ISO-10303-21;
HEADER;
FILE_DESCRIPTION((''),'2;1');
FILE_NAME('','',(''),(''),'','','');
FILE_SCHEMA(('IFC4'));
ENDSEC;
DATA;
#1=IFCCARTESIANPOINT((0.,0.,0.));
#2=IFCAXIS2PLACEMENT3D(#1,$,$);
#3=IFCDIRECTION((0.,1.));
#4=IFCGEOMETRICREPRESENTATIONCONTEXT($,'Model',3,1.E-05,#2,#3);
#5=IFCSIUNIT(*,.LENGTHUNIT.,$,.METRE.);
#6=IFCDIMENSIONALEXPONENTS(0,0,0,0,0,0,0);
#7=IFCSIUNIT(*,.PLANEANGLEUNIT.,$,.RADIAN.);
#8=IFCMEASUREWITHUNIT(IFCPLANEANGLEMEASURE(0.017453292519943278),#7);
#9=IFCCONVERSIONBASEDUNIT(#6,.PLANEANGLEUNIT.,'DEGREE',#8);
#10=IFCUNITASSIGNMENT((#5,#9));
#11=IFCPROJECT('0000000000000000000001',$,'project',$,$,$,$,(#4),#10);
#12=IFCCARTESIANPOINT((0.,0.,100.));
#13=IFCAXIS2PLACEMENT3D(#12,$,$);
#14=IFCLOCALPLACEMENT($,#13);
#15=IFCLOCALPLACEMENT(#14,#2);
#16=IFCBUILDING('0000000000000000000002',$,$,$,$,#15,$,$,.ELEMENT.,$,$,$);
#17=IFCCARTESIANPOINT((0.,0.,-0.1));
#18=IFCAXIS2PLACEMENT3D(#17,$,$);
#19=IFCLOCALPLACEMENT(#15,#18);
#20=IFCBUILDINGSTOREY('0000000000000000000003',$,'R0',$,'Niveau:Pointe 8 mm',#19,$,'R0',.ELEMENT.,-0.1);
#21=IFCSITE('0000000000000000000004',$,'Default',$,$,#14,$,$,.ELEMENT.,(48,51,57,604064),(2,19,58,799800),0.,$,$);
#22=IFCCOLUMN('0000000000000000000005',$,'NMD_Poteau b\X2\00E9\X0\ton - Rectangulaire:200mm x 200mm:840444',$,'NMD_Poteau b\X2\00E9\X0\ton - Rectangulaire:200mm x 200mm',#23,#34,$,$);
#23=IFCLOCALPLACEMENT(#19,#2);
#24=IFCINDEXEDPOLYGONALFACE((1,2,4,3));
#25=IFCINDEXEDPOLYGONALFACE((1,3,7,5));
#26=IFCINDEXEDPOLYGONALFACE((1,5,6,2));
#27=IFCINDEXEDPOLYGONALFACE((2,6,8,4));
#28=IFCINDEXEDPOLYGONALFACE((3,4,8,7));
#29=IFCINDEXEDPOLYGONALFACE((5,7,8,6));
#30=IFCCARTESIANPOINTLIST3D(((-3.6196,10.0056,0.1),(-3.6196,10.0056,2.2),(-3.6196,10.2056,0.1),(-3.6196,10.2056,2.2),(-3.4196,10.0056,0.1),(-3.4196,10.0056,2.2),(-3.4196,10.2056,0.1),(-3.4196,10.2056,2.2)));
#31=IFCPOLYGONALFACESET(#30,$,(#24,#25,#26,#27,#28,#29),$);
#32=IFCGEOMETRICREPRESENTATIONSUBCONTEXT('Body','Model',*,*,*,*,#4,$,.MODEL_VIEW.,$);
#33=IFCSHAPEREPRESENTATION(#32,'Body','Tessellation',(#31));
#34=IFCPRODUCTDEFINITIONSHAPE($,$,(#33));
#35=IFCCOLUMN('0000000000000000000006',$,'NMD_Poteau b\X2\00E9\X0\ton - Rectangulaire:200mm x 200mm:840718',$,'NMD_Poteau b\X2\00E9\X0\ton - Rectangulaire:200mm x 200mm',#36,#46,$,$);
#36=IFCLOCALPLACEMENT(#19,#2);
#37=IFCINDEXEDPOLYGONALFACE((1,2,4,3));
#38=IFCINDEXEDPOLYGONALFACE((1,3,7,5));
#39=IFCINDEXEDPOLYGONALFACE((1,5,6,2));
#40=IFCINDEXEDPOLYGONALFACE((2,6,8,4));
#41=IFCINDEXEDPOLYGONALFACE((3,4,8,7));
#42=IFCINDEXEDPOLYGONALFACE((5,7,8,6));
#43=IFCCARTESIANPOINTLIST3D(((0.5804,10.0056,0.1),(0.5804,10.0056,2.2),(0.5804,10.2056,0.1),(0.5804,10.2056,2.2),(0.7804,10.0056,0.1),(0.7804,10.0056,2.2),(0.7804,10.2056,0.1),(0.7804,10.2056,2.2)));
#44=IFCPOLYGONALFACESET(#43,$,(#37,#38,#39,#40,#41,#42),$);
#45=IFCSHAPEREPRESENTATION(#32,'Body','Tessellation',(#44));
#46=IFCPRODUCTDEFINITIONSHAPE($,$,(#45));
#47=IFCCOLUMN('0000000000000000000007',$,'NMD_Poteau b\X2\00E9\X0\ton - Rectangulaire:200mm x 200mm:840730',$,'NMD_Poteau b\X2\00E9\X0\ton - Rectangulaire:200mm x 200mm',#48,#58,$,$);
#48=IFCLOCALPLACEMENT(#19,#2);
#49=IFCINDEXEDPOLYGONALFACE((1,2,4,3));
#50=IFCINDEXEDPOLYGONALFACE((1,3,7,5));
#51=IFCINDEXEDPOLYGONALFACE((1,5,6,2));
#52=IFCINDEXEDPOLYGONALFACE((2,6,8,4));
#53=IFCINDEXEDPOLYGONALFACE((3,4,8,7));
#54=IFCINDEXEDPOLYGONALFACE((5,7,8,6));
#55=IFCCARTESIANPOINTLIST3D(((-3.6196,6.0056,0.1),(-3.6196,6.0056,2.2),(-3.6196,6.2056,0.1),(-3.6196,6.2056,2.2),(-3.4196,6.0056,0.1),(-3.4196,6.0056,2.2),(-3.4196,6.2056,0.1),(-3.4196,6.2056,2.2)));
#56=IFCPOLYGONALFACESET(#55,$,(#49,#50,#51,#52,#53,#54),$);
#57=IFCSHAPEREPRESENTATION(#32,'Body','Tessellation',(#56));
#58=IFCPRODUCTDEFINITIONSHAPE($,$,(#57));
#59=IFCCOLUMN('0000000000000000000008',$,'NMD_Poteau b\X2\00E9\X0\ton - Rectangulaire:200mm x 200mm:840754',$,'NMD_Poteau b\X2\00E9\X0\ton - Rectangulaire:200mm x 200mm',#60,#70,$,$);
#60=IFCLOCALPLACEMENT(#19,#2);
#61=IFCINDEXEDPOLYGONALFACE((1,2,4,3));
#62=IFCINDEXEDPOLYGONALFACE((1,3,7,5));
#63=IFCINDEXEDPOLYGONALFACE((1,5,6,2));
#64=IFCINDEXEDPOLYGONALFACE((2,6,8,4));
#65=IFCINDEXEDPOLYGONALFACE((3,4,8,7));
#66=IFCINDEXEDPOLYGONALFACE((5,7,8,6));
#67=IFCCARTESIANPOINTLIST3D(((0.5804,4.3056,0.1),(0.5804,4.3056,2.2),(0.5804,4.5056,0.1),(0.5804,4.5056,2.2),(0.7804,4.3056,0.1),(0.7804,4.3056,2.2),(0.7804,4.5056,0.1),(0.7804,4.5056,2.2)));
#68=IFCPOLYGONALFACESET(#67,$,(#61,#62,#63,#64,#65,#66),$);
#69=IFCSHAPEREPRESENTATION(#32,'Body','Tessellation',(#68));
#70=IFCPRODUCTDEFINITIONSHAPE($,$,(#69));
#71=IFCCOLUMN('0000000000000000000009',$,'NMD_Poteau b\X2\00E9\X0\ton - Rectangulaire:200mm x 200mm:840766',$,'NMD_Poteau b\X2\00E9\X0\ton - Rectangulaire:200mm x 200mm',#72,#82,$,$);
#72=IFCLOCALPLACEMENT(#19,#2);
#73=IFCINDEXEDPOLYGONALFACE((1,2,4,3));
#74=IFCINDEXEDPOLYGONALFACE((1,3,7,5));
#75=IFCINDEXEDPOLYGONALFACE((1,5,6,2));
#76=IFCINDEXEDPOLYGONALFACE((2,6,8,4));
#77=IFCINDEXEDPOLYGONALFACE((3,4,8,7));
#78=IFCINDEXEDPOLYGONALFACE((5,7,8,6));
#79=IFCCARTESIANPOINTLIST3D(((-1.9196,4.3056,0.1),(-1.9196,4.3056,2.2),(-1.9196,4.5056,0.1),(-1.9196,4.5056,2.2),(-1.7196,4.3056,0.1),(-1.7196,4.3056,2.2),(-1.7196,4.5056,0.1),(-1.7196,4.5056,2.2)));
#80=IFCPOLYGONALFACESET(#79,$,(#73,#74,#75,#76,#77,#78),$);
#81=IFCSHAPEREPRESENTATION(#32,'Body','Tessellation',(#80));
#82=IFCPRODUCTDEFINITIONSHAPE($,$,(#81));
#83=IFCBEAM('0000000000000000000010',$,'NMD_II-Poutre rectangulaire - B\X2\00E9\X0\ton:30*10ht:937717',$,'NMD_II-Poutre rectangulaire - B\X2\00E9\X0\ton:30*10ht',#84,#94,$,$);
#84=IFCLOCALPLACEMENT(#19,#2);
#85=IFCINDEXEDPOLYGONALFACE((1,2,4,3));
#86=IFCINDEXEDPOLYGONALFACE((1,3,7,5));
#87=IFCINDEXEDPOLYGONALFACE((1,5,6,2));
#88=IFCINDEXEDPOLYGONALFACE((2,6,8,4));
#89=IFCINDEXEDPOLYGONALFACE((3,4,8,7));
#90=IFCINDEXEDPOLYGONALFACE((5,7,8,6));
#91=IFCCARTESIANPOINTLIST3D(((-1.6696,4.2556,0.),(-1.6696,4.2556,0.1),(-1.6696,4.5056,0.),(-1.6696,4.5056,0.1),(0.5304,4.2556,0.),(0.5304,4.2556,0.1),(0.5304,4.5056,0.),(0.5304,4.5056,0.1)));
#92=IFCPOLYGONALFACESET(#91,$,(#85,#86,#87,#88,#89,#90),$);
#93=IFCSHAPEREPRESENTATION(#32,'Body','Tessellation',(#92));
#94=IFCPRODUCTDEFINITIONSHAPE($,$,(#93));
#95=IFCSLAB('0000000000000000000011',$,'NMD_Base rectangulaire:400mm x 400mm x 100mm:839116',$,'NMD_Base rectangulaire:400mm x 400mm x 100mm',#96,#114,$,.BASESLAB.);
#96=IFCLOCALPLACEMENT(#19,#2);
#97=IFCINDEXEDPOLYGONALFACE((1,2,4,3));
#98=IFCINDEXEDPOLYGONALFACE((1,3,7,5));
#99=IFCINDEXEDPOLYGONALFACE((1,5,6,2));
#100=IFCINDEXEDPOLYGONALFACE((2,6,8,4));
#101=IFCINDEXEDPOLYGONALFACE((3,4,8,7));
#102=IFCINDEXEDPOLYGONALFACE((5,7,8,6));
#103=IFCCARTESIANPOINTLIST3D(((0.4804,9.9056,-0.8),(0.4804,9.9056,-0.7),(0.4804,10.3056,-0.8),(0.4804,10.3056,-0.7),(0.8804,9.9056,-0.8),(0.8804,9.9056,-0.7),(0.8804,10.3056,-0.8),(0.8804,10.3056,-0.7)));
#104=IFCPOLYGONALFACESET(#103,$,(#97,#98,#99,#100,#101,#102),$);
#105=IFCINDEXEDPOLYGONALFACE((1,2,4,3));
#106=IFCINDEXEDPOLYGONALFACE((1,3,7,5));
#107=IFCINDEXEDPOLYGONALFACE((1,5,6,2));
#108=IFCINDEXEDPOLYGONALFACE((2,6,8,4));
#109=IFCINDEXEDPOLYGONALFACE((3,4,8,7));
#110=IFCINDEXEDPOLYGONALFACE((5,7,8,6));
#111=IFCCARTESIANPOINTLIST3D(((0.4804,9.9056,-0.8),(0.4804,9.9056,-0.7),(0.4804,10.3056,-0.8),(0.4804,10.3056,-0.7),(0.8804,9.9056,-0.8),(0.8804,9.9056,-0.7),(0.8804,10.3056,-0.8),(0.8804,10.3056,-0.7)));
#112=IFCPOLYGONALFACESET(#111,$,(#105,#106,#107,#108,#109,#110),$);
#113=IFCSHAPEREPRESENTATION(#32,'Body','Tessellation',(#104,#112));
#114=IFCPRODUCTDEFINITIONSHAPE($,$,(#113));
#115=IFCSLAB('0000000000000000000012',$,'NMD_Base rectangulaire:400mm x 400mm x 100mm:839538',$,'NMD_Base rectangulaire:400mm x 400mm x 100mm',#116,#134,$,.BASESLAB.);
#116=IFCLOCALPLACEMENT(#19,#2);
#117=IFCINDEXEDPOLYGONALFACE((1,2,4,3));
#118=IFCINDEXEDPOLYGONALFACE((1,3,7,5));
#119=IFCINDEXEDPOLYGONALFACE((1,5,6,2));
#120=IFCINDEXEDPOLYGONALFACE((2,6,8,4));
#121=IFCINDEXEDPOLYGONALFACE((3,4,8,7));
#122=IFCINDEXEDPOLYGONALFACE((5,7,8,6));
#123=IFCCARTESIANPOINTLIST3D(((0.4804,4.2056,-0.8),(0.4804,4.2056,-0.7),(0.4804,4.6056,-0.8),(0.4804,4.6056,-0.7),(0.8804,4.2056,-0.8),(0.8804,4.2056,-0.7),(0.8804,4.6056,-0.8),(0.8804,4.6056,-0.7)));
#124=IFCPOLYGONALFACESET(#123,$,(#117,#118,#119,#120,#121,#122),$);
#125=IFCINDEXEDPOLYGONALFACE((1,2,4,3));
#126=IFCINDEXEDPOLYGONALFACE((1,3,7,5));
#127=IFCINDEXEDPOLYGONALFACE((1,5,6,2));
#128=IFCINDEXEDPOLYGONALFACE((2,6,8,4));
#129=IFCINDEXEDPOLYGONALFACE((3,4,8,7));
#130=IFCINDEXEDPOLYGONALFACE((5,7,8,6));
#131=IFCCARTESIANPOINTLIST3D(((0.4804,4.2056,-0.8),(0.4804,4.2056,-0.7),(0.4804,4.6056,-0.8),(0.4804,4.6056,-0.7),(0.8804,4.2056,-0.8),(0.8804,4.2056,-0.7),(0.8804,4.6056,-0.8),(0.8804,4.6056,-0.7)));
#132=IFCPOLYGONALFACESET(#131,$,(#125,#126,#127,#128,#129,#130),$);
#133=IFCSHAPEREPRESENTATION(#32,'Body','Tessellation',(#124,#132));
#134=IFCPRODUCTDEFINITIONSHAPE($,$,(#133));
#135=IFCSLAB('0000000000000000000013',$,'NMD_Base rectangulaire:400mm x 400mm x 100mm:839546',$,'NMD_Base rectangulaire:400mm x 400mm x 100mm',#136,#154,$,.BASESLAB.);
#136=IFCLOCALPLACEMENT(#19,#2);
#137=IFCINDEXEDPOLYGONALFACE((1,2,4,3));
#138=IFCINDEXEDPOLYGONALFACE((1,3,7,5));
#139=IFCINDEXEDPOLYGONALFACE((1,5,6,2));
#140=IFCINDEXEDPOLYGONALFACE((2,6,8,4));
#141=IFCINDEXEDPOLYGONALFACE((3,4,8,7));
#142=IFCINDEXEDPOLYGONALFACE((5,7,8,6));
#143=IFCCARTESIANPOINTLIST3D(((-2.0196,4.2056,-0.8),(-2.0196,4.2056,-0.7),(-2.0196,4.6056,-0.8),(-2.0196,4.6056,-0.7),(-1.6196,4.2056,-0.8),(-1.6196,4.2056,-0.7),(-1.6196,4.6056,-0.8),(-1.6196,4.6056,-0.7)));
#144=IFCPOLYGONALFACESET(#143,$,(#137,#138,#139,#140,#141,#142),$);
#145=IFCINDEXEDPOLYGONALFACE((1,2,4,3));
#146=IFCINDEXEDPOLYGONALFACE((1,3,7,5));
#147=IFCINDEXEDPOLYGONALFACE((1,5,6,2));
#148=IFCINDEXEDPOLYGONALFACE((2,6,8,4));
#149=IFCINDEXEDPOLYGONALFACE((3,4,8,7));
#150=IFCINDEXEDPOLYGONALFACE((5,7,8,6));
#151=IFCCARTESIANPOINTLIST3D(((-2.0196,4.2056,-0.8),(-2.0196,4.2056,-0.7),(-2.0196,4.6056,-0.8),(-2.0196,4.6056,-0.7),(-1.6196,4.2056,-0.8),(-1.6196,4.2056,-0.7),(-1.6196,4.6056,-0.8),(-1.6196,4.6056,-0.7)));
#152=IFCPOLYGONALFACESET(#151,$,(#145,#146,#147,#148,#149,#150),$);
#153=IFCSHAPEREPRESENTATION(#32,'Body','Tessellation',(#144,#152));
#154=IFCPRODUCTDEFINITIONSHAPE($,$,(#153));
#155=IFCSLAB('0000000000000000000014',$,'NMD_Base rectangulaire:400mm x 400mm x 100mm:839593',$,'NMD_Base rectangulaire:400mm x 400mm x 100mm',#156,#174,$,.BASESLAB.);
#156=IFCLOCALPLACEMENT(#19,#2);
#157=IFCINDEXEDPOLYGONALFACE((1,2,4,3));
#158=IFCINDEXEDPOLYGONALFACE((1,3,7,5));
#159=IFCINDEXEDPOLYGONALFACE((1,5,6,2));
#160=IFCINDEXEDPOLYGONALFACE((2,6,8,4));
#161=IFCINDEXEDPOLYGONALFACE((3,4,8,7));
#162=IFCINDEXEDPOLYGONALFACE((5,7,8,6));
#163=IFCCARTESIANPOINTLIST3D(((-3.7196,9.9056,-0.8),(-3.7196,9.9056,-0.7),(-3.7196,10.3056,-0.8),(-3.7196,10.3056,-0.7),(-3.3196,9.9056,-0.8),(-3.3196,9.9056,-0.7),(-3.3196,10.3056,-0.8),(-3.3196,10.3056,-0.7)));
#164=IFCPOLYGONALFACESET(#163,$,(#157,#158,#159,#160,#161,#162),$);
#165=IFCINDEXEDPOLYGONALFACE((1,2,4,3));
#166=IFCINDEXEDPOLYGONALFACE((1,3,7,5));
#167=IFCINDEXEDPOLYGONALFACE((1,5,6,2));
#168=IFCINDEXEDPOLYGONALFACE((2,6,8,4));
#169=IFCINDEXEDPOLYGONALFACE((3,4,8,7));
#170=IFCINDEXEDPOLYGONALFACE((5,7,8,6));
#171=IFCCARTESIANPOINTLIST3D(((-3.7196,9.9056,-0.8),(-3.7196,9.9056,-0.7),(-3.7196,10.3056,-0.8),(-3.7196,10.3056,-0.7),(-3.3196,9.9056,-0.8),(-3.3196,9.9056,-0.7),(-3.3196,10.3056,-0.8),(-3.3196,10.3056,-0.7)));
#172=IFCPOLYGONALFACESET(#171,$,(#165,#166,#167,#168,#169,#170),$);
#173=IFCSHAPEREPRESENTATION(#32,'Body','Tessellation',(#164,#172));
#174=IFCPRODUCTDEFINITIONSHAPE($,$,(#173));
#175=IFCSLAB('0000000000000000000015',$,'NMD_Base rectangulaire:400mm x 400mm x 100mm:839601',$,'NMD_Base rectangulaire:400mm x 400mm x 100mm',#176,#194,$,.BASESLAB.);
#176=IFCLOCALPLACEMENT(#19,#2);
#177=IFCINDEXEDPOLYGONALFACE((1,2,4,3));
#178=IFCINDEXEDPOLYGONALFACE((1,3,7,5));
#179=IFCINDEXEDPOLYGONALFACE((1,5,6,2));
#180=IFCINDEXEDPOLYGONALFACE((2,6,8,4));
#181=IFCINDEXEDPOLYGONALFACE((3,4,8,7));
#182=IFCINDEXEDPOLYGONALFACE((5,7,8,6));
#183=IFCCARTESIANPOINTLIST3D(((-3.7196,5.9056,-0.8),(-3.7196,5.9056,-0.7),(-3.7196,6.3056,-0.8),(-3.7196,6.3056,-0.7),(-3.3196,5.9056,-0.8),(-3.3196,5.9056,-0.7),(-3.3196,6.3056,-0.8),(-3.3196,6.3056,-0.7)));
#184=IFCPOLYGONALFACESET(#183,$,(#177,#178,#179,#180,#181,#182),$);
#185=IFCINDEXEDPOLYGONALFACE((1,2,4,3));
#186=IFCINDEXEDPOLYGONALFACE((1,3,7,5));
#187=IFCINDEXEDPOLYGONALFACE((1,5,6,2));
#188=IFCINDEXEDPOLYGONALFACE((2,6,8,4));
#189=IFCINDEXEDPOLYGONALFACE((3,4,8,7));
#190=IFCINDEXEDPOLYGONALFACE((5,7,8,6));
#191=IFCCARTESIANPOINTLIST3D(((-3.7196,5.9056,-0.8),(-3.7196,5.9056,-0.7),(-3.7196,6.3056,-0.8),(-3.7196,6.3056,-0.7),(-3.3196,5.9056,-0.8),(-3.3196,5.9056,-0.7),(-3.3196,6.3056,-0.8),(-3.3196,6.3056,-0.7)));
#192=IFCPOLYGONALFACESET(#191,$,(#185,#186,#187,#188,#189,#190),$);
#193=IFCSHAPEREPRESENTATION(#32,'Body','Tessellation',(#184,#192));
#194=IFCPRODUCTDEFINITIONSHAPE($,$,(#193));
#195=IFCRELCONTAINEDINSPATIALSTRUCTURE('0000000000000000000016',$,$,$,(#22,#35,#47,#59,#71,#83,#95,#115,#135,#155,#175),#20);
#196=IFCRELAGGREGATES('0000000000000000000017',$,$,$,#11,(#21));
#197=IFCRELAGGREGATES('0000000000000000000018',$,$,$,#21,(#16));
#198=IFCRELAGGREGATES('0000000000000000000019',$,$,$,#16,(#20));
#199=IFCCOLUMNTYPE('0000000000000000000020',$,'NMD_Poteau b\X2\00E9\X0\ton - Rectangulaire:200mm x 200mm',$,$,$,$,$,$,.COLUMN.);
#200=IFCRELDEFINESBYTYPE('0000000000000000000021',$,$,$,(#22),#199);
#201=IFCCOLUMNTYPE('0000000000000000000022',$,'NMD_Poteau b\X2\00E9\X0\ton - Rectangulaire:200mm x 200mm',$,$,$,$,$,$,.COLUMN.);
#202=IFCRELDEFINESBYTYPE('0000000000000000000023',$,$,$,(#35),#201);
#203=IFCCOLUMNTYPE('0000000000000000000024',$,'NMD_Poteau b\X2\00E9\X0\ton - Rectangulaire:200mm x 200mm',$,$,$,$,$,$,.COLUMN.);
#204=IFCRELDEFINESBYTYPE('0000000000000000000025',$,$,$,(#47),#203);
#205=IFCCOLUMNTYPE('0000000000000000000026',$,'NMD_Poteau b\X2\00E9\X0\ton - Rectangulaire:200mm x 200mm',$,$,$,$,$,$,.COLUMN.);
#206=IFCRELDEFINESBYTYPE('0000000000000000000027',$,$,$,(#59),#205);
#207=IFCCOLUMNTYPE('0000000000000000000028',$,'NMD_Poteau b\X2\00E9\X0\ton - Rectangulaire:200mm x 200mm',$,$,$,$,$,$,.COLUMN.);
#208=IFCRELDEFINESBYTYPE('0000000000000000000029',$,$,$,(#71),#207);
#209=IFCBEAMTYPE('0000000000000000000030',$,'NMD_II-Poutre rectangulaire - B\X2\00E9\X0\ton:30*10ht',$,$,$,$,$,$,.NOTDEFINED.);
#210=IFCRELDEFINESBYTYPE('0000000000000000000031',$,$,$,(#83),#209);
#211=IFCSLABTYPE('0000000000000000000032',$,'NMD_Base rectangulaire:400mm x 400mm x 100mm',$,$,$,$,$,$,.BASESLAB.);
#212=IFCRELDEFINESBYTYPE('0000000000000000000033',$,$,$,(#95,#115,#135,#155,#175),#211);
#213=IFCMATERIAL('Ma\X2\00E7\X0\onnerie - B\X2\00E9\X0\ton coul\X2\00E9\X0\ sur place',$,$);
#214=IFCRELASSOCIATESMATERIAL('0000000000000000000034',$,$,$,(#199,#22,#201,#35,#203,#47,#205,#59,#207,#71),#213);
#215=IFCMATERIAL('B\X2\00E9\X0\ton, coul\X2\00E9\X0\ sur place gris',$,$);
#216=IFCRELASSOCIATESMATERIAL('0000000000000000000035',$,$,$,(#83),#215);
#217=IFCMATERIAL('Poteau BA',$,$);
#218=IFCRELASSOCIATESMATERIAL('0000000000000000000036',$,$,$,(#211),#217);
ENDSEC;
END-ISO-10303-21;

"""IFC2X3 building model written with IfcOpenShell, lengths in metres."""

from ifc_helpers import new_model, entity, si_unit, converted_unit, direction, frame, frame_2d, origin, origin_2d_with_axis, place, context, subcontext, project, spatial, rectangle, extrude, source, transform, mapped, material, type_object, type_shapes, element, save


model = new_model("IFC2X3")

# Units and contexts
model_context = context("Model", 3, precision=1e-05, world=origin(), true_north=direction((0.0, 1.0)))
body_context = subcontext(model_context, "Body", "Model", "MODEL_VIEW")
ifc_project = project(units=[si_unit("LENGTHUNIT", "METRE"), converted_unit("PLANEANGLEUNIT", "DEGREE", entity("IfcPlaneAngleMeasure", 0.017453292519943278), si_unit("PLANEANGLEUNIT", "RADIAN"), dimensions=[0, 0, 0, 0, 0, 0, 0])], contexts=[model_context])

# Site, building, storey
site_placement = place(None, frame((0.0, 0.0, 100.0)))
site = spatial("IfcSite", under=ifc_project, at=site_placement, Name="Default", CompositionType="ELEMENT", RefLatitude=(48, 51, 57, 604064), RefLongitude=(2, 19, 58, 799800), RefElevation=0.0)
building_placement = place(site_placement, origin())
building = spatial("IfcBuilding", under=site, at=building_placement, CompositionType="ELEMENT")
storey_placement = place(building_placement, frame((0.0, 0.0, -0.1)))
storey = spatial("IfcBuildingStorey", under=building, at=storey_placement, Name="R0", ObjectType="Niveau:Pointe 8 mm", LongName="R0", CompositionType="ELEMENT", Elevation=-0.1)

# Columns
ifc_material_1 = material(Name="Maçonnerie - Béton coulé sur place")
column_type_1 = type_object("IfcColumnType", Name="NMD_Poteau béton - Rectangulaire:200mm x 200mm", PredefinedType="COLUMN", material=ifc_material_1)
shared_shape_1 = source(origin(), body_context, "Body", "SweptSolid", [
    extrude(rectangle(XDim=0.2, YDim=0.2, at=frame_2d((0.0, 0.0), x_axis=(1.0, 0.0))), frame((-3.5196, 10.1056, 0.0), z_axis=(0.0, 0.0, 1.0), x_axis=(-1.0, 0.0, 0.0)), (0.0, 0.0, 1.0), 2.1),
])
type_shapes(column_type_1, [shared_shape_1])
column_1_placement = place(storey_placement, frame((0.0, 0.0, 0.1)))
element("IfcColumn", 1, at=column_1_placement, inside=storey, type_object=column_type_1, material=ifc_material_1, Name="NMD_Poteau béton - Rectangulaire:200mm x 200mm:840444", ObjectType="NMD_Poteau béton - Rectangulaire:200mm x 200mm", context=body_context, shape_type="MappedRepresentation", body=[
    mapped(shared_shape_1, transform((0.0, 0.0, 0.0), scale=1.0)),
])
column_type_2 = type_object("IfcColumnType", Name="NMD_Poteau béton - Rectangulaire:200mm x 200mm", PredefinedType="COLUMN", material=ifc_material_1)
shared_shape_2 = source(origin(), body_context, "Body", "SweptSolid", [
    extrude(rectangle(XDim=0.2, YDim=0.2, at=frame_2d((0.0, 0.0), x_axis=(1.0, 0.0))), frame((0.6804, 10.1056, 0.0), z_axis=(0.0, 0.0, 1.0), x_axis=(-1.0, 0.0, 0.0)), (0.0, 0.0, 1.0), 2.1),
])
type_shapes(column_type_2, [shared_shape_2])
column_2_placement = place(storey_placement, frame((0.0, 0.0, 0.1)))
element("IfcColumn", 2, at=column_2_placement, inside=storey, type_object=column_type_2, material=ifc_material_1, Name="NMD_Poteau béton - Rectangulaire:200mm x 200mm:840718", ObjectType="NMD_Poteau béton - Rectangulaire:200mm x 200mm", context=body_context, shape_type="MappedRepresentation", body=[
    mapped(shared_shape_2, transform((0.0, 0.0, 0.0), scale=1.0)),
])
column_type_3 = type_object("IfcColumnType", Name="NMD_Poteau béton - Rectangulaire:200mm x 200mm", PredefinedType="COLUMN", material=ifc_material_1)
shared_shape_3 = source(origin(), body_context, "Body", "SweptSolid", [
    extrude(rectangle(XDim=0.2, YDim=0.2, at=origin_2d_with_axis()), frame((-3.5196, 6.1056, 0.0), z_axis=(0.0, 0.0, 1.0), x_axis=(-1.0, 0.0, 0.0)), (0.0, 0.0, 1.0), 2.1),
])
type_shapes(column_type_3, [shared_shape_3])
column_3_placement = place(storey_placement, frame((0.0, 0.0, 0.1)))
element("IfcColumn", 3, at=column_3_placement, inside=storey, type_object=column_type_3, material=ifc_material_1, Name="NMD_Poteau béton - Rectangulaire:200mm x 200mm:840730", ObjectType="NMD_Poteau béton - Rectangulaire:200mm x 200mm", context=body_context, shape_type="MappedRepresentation", body=[
    mapped(shared_shape_3, transform((0.0, 0.0, 0.0), scale=1.0)),
])
column_type_4 = type_object("IfcColumnType", Name="NMD_Poteau béton - Rectangulaire:200mm x 200mm", PredefinedType="COLUMN", material=ifc_material_1)
shared_shape_4 = source(origin(), body_context, "Body", "SweptSolid", [
    extrude(rectangle(XDim=0.2, YDim=0.2, at=origin_2d_with_axis()), frame((0.6804, 4.4056, 0.0), z_axis=(0.0, 0.0, 1.0), x_axis=(-1.0, 0.0, 0.0)), (0.0, 0.0, 1.0), 2.1),
])
type_shapes(column_type_4, [shared_shape_4])
column_4_placement = place(storey_placement, frame((0.0, 0.0, 0.1)))
element("IfcColumn", 4, at=column_4_placement, inside=storey, type_object=column_type_4, material=ifc_material_1, Name="NMD_Poteau béton - Rectangulaire:200mm x 200mm:840754", ObjectType="NMD_Poteau béton - Rectangulaire:200mm x 200mm", context=body_context, shape_type="MappedRepresentation", body=[
    mapped(shared_shape_4, transform((0.0, 0.0, 0.0), scale=1.0)),
])
column_type_5 = type_object("IfcColumnType", Name="NMD_Poteau béton - Rectangulaire:200mm x 200mm", PredefinedType="COLUMN", material=ifc_material_1)
shared_shape_5 = source(origin(), body_context, "Body", "SweptSolid", [
    extrude(rectangle(XDim=0.2, YDim=0.2, at=origin_2d_with_axis()), frame((-1.8196, 4.4056, 0.0), z_axis=(0.0, 0.0, 1.0), x_axis=(-1.0, 0.0, 0.0)), (0.0, 0.0, 1.0), 2.1),
])
type_shapes(column_type_5, [shared_shape_5])
column_5_placement = place(storey_placement, frame((0.0, 0.0, 0.1)))
element("IfcColumn", 5, at=column_5_placement, inside=storey, type_object=column_type_5, material=ifc_material_1, Name="NMD_Poteau béton - Rectangulaire:200mm x 200mm:840766", ObjectType="NMD_Poteau béton - Rectangulaire:200mm x 200mm", context=body_context, shape_type="MappedRepresentation", body=[
    mapped(shared_shape_5, transform((0.0, 0.0, 0.0), scale=1.0)),
])

# Beam
ifc_material_2 = material(Name="Béton, coulé sur place gris")
beam_type = type_object("IfcBeamType", Name="NMD_II-Poutre rectangulaire - Béton:30*10ht", PredefinedType="NOTDEFINED")
beam_placement = place(storey_placement, frame((0.5304, 4.4056, 0.1), z_axis=(0.0, 0.0, 1.0), x_axis=(-1.0, 0.0, 0.0)))
element("IfcBeam", 6, at=beam_placement, inside=storey, type_object=beam_type, material=ifc_material_2, Name="NMD_II-Poutre rectangulaire - Béton:30*10ht:937717", ObjectType="NMD_II-Poutre rectangulaire - Béton:30*10ht", context=body_context, shape_type="SweptSolid", body=[
    extrude(rectangle(XDim=0.1, YDim=0.25, at=frame_2d((0.0, 0.0), x_axis=(1.0, 0.0))), frame((0.0, 0.025, -0.05), z_axis=(1.0, 0.0, 0.0), x_axis=(0.0, 0.0, -1.0)), (0.0, 0.0, 1.0), 2.2),
])

# Slabs
ifc_material_3 = material(Name="Poteau BA")
slab_type_1 = type_object("IfcSlabType", Name="NMD_Base rectangulaire:400mm x 400mm x 100mm", PredefinedType="BASESLAB", material=ifc_material_3)
slab_1_placement = place(storey_placement, origin())
element("IfcSlab", 7, at=slab_1_placement, inside=storey, type_object=slab_type_1, Name="NMD_Base rectangulaire:400mm x 400mm x 100mm:839116", ObjectType="NMD_Base rectangulaire:400mm x 400mm x 100mm", PredefinedType="BASESLAB", context=body_context, shape_type="SweptSolid", body=[
    extrude(rectangle(XDim=0.4, YDim=0.4, at=frame_2d((0.0, 0.0), x_axis=(1.0, 0.0))), frame((0.6804, 10.1056, -0.8), z_axis=(0.0, 0.0, 1.0), x_axis=(-1.0, 0.0, 0.0)), (0.0, 0.0, 1.0), 0.1),
    extrude(rectangle(XDim=0.4, YDim=0.4, at=frame_2d((0.0, 0.0), x_axis=(1.0, 0.0))), frame((0.6804, 10.1056, -0.8), z_axis=(0.0, 0.0, 1.0), x_axis=(-1.0, 0.0, 0.0)), (0.0, 0.0, 1.0), 0.1),
])
slab_2_placement = place(storey_placement, origin())
element("IfcSlab", 8, at=slab_2_placement, inside=storey, type_object=slab_type_1, Name="NMD_Base rectangulaire:400mm x 400mm x 100mm:839538", ObjectType="NMD_Base rectangulaire:400mm x 400mm x 100mm", PredefinedType="BASESLAB", context=body_context, shape_type="SweptSolid", body=[
    extrude(rectangle(XDim=0.4, YDim=0.4, at=frame_2d((0.0, 0.0), x_axis=(1.0, 0.0))), frame((0.6804, 4.4056, -0.8), z_axis=(0.0, 0.0, 1.0), x_axis=(-1.0, 0.0, 0.0)), (0.0, 0.0, 1.0), 0.1),
    extrude(rectangle(XDim=0.4, YDim=0.4, at=frame_2d((0.0, 0.0), x_axis=(1.0, 0.0))), frame((0.6804, 4.4056, -0.8), z_axis=(0.0, 0.0, 1.0), x_axis=(-1.0, 0.0, 0.0)), (0.0, 0.0, 1.0), 0.1),
])
slab_3_placement = place(storey_placement, origin())
element("IfcSlab", 9, at=slab_3_placement, inside=storey, type_object=slab_type_1, Name="NMD_Base rectangulaire:400mm x 400mm x 100mm:839546", ObjectType="NMD_Base rectangulaire:400mm x 400mm x 100mm", PredefinedType="BASESLAB", context=body_context, shape_type="SweptSolid", body=[
    extrude(rectangle(XDim=0.4, YDim=0.4, at=origin_2d_with_axis()), frame((-1.8196, 4.4056, -0.8), z_axis=(0.0, 0.0, 1.0), x_axis=(-1.0, 0.0, 0.0)), (0.0, 0.0, 1.0), 0.1),
    extrude(rectangle(XDim=0.4, YDim=0.4, at=origin_2d_with_axis()), frame((-1.8196, 4.4056, -0.8), z_axis=(0.0, 0.0, 1.0), x_axis=(-1.0, 0.0, 0.0)), (0.0, 0.0, 1.0), 0.1),
])
slab_4_placement = place(storey_placement, origin())
element("IfcSlab", 10, at=slab_4_placement, inside=storey, type_object=slab_type_1, Name="NMD_Base rectangulaire:400mm x 400mm x 100mm:839593", ObjectType="NMD_Base rectangulaire:400mm x 400mm x 100mm", PredefinedType="BASESLAB", context=body_context, shape_type="SweptSolid", body=[
    extrude(rectangle(XDim=0.4, YDim=0.4, at=origin_2d_with_axis()), frame((-3.5196, 10.1056, -0.8), z_axis=(0.0, 0.0, 1.0), x_axis=(-1.0, 0.0, 0.0)), (0.0, 0.0, 1.0), 0.1),
    extrude(rectangle(XDim=0.4, YDim=0.4, at=origin_2d_with_axis()), frame((-3.5196, 10.1056, -0.8), z_axis=(0.0, 0.0, 1.0), x_axis=(-1.0, 0.0, 0.0)), (0.0, 0.0, 1.0), 0.1),
])
slab_5_placement = place(storey_placement, origin())
element("IfcSlab", 11, at=slab_5_placement, inside=storey, type_object=slab_type_1, Name="NMD_Base rectangulaire:400mm x 400mm x 100mm:839601", ObjectType="NMD_Base rectangulaire:400mm x 400mm x 100mm", PredefinedType="BASESLAB", context=body_context, shape_type="SweptSolid", body=[
    extrude(rectangle(XDim=0.4, YDim=0.4, at=origin_2d_with_axis()), frame((-3.5196, 6.1056, -0.8), z_axis=(0.0, 0.0, 1.0), x_axis=(-1.0, 0.0, 0.0)), (0.0, 0.0, 1.0), 0.1),
    extrude(rectangle(XDim=0.4, YDim=0.4, at=origin_2d_with_axis()), frame((-3.5196, 6.1056, -0.8), z_axis=(0.0, 0.0, 1.0), x_axis=(-1.0, 0.0, 0.0)), (0.0, 0.0, 1.0), 0.1),
])

save(model, "model.ifc")
